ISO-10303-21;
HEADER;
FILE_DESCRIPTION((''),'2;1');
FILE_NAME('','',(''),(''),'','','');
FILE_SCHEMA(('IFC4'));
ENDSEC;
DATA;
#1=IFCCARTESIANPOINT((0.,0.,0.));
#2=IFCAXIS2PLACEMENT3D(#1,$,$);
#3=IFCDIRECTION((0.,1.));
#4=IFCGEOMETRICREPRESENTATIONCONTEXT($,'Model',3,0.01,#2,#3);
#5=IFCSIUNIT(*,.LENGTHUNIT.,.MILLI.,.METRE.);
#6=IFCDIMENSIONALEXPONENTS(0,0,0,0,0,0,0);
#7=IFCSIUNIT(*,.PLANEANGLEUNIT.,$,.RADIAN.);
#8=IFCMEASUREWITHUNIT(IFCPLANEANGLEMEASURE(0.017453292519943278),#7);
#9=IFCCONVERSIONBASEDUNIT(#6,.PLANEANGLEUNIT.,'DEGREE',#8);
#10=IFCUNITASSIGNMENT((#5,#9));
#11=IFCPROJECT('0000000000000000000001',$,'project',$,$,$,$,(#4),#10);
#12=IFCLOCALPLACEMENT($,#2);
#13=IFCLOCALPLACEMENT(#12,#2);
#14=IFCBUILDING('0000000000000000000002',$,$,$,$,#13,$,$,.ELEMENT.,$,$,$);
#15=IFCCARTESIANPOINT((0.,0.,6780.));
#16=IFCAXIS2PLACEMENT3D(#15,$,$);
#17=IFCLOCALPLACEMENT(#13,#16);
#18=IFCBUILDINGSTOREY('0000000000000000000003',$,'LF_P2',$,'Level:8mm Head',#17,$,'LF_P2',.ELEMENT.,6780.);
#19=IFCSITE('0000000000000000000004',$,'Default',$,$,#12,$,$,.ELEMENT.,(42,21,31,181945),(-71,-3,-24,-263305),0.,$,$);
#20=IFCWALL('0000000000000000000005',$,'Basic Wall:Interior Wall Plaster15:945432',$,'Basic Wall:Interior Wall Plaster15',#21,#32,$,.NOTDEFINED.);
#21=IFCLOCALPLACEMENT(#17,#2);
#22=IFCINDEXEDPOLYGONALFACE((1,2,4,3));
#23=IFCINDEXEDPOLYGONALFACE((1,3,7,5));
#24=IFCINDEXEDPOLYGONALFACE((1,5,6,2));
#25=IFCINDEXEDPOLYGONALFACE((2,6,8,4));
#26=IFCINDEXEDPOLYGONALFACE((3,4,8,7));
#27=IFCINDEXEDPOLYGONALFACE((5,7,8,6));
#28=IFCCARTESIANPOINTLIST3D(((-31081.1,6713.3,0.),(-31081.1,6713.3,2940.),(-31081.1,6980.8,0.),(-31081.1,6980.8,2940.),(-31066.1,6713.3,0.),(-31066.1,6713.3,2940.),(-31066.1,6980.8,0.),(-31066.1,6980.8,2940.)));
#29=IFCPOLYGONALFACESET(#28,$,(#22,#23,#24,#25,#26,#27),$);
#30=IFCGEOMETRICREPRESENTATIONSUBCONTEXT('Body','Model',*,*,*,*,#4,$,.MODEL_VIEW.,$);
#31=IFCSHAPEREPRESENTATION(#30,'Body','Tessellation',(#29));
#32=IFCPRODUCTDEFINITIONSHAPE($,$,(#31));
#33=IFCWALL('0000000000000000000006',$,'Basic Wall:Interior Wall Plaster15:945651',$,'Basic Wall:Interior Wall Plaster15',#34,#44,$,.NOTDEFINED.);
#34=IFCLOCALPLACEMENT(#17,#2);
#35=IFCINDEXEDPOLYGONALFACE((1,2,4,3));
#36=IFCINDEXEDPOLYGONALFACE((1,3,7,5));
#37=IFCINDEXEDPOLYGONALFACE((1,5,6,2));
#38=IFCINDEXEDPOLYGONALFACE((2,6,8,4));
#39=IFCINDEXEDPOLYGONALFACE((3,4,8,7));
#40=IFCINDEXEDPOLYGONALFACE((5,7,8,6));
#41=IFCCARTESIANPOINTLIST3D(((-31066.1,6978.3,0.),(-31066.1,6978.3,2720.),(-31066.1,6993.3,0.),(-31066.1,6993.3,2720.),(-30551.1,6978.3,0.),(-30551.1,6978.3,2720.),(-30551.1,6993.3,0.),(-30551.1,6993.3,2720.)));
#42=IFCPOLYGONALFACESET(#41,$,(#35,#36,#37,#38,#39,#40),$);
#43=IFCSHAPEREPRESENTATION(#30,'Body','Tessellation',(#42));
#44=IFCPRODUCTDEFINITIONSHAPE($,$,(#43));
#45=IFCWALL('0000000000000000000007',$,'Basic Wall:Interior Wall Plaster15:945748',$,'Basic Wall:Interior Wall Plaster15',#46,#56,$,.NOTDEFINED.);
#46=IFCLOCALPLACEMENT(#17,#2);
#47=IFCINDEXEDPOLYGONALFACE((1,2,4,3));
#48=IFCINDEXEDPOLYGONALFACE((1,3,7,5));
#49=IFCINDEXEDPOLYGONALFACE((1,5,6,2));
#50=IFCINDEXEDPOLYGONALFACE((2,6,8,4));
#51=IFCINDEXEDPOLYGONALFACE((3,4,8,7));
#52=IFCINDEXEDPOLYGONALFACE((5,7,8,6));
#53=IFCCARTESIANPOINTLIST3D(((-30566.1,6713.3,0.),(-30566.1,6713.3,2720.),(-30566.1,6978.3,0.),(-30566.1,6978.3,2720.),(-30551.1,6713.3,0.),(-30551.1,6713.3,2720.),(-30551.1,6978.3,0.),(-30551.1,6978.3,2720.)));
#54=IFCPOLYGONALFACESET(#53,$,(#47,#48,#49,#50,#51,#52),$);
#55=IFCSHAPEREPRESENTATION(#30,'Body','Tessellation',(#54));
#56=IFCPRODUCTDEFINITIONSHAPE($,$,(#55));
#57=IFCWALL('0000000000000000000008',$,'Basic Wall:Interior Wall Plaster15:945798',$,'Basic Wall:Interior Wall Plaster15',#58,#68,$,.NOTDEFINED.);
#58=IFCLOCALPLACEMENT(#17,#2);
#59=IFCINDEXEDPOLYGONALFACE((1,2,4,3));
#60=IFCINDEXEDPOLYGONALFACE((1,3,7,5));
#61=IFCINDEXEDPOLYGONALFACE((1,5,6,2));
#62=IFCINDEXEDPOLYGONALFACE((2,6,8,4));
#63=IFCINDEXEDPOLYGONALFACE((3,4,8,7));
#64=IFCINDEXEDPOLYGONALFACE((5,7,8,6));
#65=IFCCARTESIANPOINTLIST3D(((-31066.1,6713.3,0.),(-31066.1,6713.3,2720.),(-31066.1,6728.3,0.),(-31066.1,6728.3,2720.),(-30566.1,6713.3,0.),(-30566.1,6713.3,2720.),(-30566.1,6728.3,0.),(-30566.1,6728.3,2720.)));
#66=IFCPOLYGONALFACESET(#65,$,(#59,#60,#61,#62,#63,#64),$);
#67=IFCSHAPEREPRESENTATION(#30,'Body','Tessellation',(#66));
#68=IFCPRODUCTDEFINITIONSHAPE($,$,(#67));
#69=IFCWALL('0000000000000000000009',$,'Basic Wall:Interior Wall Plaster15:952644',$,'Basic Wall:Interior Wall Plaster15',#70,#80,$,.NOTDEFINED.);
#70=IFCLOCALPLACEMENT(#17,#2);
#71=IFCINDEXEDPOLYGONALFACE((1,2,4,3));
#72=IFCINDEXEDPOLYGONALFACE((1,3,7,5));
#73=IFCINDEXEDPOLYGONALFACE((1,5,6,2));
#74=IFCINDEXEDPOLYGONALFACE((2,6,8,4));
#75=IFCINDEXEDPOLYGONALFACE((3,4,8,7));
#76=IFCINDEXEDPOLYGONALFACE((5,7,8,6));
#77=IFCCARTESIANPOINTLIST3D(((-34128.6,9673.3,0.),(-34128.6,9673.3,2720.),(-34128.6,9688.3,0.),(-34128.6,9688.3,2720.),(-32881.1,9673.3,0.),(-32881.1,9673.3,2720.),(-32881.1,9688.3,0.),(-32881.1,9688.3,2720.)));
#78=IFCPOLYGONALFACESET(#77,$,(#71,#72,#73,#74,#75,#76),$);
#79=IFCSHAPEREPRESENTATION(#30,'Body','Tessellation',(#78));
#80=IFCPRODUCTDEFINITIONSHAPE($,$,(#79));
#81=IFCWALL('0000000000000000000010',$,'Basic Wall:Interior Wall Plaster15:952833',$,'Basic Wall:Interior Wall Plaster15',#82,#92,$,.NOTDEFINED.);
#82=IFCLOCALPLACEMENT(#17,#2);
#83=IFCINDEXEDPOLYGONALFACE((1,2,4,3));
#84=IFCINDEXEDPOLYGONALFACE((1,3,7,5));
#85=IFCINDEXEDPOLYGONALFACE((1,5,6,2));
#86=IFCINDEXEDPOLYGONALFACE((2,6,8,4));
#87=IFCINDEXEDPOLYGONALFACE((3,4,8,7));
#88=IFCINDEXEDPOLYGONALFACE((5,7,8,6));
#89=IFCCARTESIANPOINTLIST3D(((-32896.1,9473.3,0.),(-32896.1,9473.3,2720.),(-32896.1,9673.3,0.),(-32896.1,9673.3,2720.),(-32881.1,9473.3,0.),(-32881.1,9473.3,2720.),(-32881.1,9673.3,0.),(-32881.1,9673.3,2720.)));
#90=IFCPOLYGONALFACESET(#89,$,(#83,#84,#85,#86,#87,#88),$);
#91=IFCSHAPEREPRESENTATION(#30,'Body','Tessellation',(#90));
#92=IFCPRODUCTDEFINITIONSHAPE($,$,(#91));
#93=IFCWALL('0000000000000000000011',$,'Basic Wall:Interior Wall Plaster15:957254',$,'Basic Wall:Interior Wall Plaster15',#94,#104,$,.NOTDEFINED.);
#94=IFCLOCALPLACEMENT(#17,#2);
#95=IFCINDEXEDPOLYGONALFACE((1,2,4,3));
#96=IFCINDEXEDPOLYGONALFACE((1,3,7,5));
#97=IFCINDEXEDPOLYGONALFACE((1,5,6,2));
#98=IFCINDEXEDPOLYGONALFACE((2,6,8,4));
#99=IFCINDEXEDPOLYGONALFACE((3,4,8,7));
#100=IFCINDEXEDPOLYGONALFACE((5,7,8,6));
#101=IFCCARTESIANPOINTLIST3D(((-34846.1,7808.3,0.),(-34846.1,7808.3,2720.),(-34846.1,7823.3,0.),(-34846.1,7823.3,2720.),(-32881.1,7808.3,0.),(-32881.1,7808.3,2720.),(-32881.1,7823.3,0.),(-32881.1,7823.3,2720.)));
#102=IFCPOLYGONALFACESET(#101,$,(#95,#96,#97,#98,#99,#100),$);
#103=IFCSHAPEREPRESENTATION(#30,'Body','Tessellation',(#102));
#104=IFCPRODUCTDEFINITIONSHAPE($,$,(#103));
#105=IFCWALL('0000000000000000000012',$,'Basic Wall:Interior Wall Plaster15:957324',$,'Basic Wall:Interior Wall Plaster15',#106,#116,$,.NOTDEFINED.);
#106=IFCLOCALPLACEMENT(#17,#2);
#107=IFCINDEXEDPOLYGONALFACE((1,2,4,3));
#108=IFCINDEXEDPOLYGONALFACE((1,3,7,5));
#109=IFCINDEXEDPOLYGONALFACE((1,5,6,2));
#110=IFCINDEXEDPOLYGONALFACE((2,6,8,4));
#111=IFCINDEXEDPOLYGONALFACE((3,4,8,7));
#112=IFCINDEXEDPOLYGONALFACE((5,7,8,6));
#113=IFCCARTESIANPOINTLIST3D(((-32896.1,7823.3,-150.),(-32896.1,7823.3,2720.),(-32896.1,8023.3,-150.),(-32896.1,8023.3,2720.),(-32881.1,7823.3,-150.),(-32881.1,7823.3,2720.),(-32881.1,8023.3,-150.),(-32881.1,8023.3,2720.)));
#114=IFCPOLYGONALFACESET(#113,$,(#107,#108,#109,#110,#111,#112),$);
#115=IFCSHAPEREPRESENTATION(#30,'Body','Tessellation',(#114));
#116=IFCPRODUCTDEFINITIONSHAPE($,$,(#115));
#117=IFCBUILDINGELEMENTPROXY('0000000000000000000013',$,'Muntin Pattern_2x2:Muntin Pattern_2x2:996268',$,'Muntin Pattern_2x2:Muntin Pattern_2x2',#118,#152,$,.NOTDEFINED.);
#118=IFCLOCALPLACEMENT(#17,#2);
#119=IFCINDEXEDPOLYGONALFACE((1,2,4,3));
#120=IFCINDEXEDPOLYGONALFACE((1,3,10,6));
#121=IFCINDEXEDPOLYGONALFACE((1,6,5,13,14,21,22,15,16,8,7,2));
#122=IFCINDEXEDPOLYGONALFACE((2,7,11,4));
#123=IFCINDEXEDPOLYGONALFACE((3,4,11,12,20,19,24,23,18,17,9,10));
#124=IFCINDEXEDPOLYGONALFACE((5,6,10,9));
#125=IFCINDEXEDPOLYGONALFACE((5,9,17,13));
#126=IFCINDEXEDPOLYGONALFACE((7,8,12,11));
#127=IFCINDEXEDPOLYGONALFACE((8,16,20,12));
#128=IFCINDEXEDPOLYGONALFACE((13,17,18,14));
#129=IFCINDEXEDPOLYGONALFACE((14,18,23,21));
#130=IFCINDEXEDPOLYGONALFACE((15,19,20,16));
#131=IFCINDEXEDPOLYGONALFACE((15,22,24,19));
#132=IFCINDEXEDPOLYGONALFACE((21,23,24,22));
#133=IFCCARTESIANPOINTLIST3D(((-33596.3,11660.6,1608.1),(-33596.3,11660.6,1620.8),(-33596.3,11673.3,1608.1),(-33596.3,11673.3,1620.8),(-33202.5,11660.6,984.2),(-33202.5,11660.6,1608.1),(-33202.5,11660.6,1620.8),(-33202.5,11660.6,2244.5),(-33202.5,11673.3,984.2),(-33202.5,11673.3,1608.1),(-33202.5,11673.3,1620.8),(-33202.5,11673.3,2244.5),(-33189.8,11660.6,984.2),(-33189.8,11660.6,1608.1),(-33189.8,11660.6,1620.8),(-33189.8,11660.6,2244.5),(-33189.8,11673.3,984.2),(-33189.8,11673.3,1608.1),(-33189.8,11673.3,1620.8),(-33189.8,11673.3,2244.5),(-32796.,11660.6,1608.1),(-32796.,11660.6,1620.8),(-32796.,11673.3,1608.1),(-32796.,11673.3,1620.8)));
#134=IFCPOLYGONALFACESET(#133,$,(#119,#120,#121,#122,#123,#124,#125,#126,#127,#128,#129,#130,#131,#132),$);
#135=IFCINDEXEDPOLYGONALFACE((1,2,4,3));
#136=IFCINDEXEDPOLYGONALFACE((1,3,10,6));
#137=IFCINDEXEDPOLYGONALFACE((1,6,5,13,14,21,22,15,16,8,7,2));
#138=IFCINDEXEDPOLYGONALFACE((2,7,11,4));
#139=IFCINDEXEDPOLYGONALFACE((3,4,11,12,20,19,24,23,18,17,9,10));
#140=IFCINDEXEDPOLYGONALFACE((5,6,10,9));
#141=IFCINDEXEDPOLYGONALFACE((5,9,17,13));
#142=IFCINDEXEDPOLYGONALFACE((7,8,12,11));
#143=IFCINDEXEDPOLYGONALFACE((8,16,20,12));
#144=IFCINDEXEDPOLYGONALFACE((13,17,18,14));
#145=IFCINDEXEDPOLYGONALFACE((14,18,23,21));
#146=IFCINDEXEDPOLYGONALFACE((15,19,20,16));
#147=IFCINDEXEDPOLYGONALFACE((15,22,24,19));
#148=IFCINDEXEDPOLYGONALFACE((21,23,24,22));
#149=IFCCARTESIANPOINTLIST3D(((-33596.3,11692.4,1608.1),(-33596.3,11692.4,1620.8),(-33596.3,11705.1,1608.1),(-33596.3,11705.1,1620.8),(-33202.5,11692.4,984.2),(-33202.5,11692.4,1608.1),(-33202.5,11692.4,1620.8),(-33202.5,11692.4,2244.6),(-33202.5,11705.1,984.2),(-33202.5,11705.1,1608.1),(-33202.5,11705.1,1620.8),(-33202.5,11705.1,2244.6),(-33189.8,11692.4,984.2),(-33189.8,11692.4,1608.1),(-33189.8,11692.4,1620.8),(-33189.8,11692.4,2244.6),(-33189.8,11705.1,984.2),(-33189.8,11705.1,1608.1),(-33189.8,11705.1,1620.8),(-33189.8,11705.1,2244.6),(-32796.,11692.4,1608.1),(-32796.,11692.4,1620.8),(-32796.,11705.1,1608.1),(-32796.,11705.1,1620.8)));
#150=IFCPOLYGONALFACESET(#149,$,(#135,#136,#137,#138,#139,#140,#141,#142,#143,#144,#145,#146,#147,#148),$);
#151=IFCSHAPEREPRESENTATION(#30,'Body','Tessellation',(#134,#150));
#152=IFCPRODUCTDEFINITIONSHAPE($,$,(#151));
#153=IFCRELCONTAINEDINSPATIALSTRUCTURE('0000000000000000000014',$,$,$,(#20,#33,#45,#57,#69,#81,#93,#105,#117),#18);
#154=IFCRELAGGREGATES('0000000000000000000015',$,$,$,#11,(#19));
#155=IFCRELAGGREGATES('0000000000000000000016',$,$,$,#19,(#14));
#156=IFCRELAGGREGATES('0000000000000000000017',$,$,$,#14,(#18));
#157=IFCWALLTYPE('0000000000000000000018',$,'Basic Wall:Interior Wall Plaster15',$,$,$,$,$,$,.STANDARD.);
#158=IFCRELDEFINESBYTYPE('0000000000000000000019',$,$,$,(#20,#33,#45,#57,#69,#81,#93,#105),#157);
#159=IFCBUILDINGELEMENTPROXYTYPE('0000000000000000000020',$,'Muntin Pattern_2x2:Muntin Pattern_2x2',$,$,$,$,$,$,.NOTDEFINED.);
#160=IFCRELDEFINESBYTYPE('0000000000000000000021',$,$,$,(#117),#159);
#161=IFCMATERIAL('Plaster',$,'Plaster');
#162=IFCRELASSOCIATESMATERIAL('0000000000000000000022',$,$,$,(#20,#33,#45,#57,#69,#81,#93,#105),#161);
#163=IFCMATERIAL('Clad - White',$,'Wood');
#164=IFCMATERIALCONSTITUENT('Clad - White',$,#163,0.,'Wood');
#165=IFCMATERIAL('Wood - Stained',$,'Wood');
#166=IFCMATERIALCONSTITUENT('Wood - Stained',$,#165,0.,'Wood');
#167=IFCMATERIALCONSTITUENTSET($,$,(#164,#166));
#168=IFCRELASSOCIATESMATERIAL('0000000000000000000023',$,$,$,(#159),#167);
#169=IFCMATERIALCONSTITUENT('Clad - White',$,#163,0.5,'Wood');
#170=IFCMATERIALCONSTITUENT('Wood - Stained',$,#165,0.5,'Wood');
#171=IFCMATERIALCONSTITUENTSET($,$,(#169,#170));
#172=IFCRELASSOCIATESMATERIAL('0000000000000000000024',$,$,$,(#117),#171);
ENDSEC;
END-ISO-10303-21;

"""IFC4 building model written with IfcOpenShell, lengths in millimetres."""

from ifc_helpers import new_model, entity, si_unit, converted_unit, direction, frame, origin, place, context, subcontext, project, spatial, indexed_curve, outline, extrude, source, transform, mapped, material, constituent, constituent_set, type_object, type_shapes, element, save


model = new_model("IFC4")

# Units and contexts
model_context = context("Model", 3, precision=0.01, world=origin(), true_north=direction((0.0, 1.0)))
body_context = subcontext(model_context, "Body", "Model", "MODEL_VIEW")
ifc_project = project(units=[si_unit("LENGTHUNIT", "METRE", prefix="MILLI"), converted_unit("PLANEANGLEUNIT", "DEGREE", entity("IfcPlaneAngleMeasure", 0.017453292519943278), si_unit("PLANEANGLEUNIT", "RADIAN"), dimensions=[0, 0, 0, 0, 0, 0, 0])], contexts=[model_context])

# Site, building, storey
site_placement = place(None, origin())
site = spatial("IfcSite", under=ifc_project, at=site_placement, Name="Default", CompositionType="ELEMENT", RefLatitude=(42, 21, 31, 181945), RefLongitude=(-71, -3, -24, -263305), RefElevation=0.0)
building_placement = place(site_placement, origin())
building = spatial("IfcBuilding", under=site, at=building_placement, CompositionType="ELEMENT")
storey_placement = place(building_placement, frame((0.0, 0.0, 6780.0)))
storey = spatial("IfcBuildingStorey", under=building, at=storey_placement, Name="LF_P2", ObjectType="Level:8mm Head", LongName="LF_P2", CompositionType="ELEMENT", Elevation=6780.0)

# Walls
ifc_material_1 = material(Name="Plaster", Category="Plaster")
wall_type_1 = type_object("IfcWallType", Name="Basic Wall:Interior Wall Plaster15", PredefinedType="STANDARD")
wall_1_placement = place(storey_placement, frame((-31073.6, 6980.8, 0.0), z_axis=(0.0, 0.0, 1.0), x_axis=(0.0, -1.0, 0.0)))
element("IfcWall", 1, at=wall_1_placement, inside=storey, type_object=wall_type_1, material=ifc_material_1, Name="Basic Wall:Interior Wall Plaster15:945432", ObjectType="Basic Wall:Interior Wall Plaster15", PredefinedType="NOTDEFINED", context=body_context, shape_type="SweptSolid", body=[
    extrude(outline(indexed_curve([(267.5, 7.5), (0.0, 7.5), (0.0, -7.5), (267.5, -7.5), (267.5, 7.5)], self_intersect=False)), origin(), (0.0, 0.0, 1.0), 2940.0),
])
wall_2_placement = place(storey_placement, frame((-31066.1, 6985.8, 0.0)))
element("IfcWall", 2, at=wall_2_placement, inside=storey, type_object=wall_type_1, material=ifc_material_1, Name="Basic Wall:Interior Wall Plaster15:945651", ObjectType="Basic Wall:Interior Wall Plaster15", PredefinedType="NOTDEFINED", context=body_context, shape_type="SweptSolid", body=[
    extrude(outline(indexed_curve([(515.0, 7.5), (0.0, 7.5), (0.0, -7.5), (515.0, -7.5), (515.0, 7.5)], self_intersect=False)), origin(), (0.0, 0.0, 1.0), 2720.0),
])
wall_3_placement = place(storey_placement, frame((-30558.6, 6978.3, 0.0), z_axis=(0.0, 0.0, 1.0), x_axis=(0.0, -1.0, 0.0)))
element("IfcWall", 3, at=wall_3_placement, inside=storey, type_object=wall_type_1, material=ifc_material_1, Name="Basic Wall:Interior Wall Plaster15:945748", ObjectType="Basic Wall:Interior Wall Plaster15", PredefinedType="NOTDEFINED", context=body_context, shape_type="SweptSolid", body=[
    extrude(outline(indexed_curve([(265.0, 7.5), (0.0, 7.5), (0.0, -7.5), (265.0, -7.5), (265.0, 7.5)], self_intersect=False)), origin(), (0.0, 0.0, 1.0), 2720.0),
])
wall_4_placement = place(storey_placement, frame((-30566.1, 6720.8, 0.0), z_axis=(0.0, 0.0, 1.0), x_axis=(-1.0, 0.0, 0.0)))
element("IfcWall", 4, at=wall_4_placement, inside=storey, type_object=wall_type_1, material=ifc_material_1, Name="Basic Wall:Interior Wall Plaster15:945798", ObjectType="Basic Wall:Interior Wall Plaster15", PredefinedType="NOTDEFINED", context=body_context, shape_type="SweptSolid", body=[
    extrude(outline(indexed_curve([(500.0, 7.5), (0.0, 7.5), (0.0, -7.5), (500.0, -7.5), (500.0, 7.5)], self_intersect=False)), origin(), (0.0, 0.0, 1.0), 2720.0),
])
wall_5_placement = place(storey_placement, frame((-34128.6, 9680.8, 0.0)))
element("IfcWall", 5, at=wall_5_placement, inside=storey, type_object=wall_type_1, material=ifc_material_1, Name="Basic Wall:Interior Wall Plaster15:952644", ObjectType="Basic Wall:Interior Wall Plaster15", PredefinedType="NOTDEFINED", context=body_context, shape_type="SweptSolid", body=[
    extrude(outline(indexed_curve([(1247.5, 7.5), (0.0, 7.5), (0.0, -7.5), (1247.5, -7.5), (1247.5, 7.5)], self_intersect=False)), origin(), (0.0, 0.0, 1.0), 2720.0),
])
wall_6_placement = place(storey_placement, frame((-32888.6, 9673.3, 0.0), z_axis=(0.0, 0.0, 1.0), x_axis=(0.0, -1.0, 0.0)))
element("IfcWall", 6, at=wall_6_placement, inside=storey, type_object=wall_type_1, material=ifc_material_1, Name="Basic Wall:Interior Wall Plaster15:952833", ObjectType="Basic Wall:Interior Wall Plaster15", PredefinedType="NOTDEFINED", context=body_context, shape_type="SweptSolid", body=[
    extrude(outline(indexed_curve([(200.0, 7.5), (0.0, 7.5), (0.0, -7.5), (200.0, -7.5), (200.0, 7.5)], self_intersect=False)), origin(), (0.0, 0.0, 1.0), 2720.0),
])
wall_7_placement = place(storey_placement, frame((-34846.1, 7815.8, 0.0)))
element("IfcWall", 7, at=wall_7_placement, inside=storey, type_object=wall_type_1, material=ifc_material_1, Name="Basic Wall:Interior Wall Plaster15:957254", ObjectType="Basic Wall:Interior Wall Plaster15", PredefinedType="NOTDEFINED", context=body_context, shape_type="SweptSolid", body=[
    extrude(outline(indexed_curve([(1965.0, 7.5), (0.0, 7.5), (0.0, -7.5), (1965.0, -7.5), (1965.0, 7.5)], self_intersect=False)), origin(), (0.0, 0.0, 1.0), 2720.0),
])
wall_8_placement = place(storey_placement, frame((-32888.6, 7823.3, -150.0), z_axis=(0.0, 0.0, 1.0), x_axis=(0.0, 1.0, 0.0)))
element("IfcWall", 8, at=wall_8_placement, inside=storey, type_object=wall_type_1, material=ifc_material_1, Name="Basic Wall:Interior Wall Plaster15:957324", ObjectType="Basic Wall:Interior Wall Plaster15", PredefinedType="NOTDEFINED", context=body_context, shape_type="SweptSolid", body=[
    extrude(outline(indexed_curve([(200.0, 7.5), (0.0, 7.5), (0.0, -7.5), (200.0, -7.5), (200.0, 7.5)], self_intersect=False)), origin(), (0.0, 0.0, 1.0), 2870.0),
])

# Building element proxy
ifc_material_2 = material(Name="Clad - White", Category="Wood")
ifc_constituent_1 = constituent(ifc_material_2, Name="Clad - White", Category="Wood", fraction=0.5)
ifc_material_3 = material(Name="Wood - Stained", Category="Wood")
ifc_constituent_2 = constituent(ifc_material_3, Name="Wood - Stained", Category="Wood", fraction=0.5)
ifc_constituent_set_1 = constituent_set(constituents=[ifc_constituent_1, ifc_constituent_2])
ifc_constituent_3 = constituent(ifc_material_2, Name="Clad - White", Category="Wood", fraction=0.0)
ifc_constituent_4 = constituent(ifc_material_3, Name="Wood - Stained", Category="Wood", fraction=0.0)
ifc_constituent_set_2 = constituent_set(constituents=[ifc_constituent_3, ifc_constituent_4])
building_element_proxy_type_1 = type_object("IfcBuildingElementProxyType", Name="Muntin Pattern_2x2:Muntin Pattern_2x2", PredefinedType="NOTDEFINED", material=ifc_constituent_set_2)
shared_shape_1 = source(origin(), body_context, "Body", "SweptSolid", [
    extrude(outline(indexed_curve([(6.4, -6.4), (630.1, -6.4), (630.1, 6.3), (6.4, 6.3), (6.4, 400.2), (-6.3, 400.2), (-6.3, 6.3), (-630.2, 6.3), (-630.2, -6.4), (-6.3, -6.4), (-6.3, -400.1), (6.4, -400.1), (6.4, -6.4)], self_intersect=False)), frame((0.0, 9.5, 630.1), z_axis=(0.0, 1.0, 0.0), x_axis=(0.0, 0.0, 1.0)), (0.0, 0.0, 1.0), 12.7),
    extrude(outline(indexed_curve([(6.4, -6.4), (630.2, -6.4), (630.2, 6.3), (6.4, 6.3), (6.4, 400.2), (-6.3, 400.2), (-6.3, 6.3), (-630.2, 6.3), (-630.2, -6.4), (-6.3, -6.4), (-6.3, -400.1), (6.4, -400.1), (6.4, -6.4)], self_intersect=False)), frame((0.0, -22.2, 630.2), z_axis=(0.0, 1.0, 0.0), x_axis=(0.0, 0.0, 1.0)), (0.0, 0.0, 1.0), 12.7),
])
type_shapes(building_element_proxy_type_1, [shared_shape_1])
proxy_1_placement = place(storey_placement, frame((-33196.1, 11682.9, 984.3), z_axis=(0.0, 0.0, 1.0), x_axis=(-1.0, 0.0, 0.0)))
element("IfcBuildingElementProxy", 9, at=proxy_1_placement, inside=storey, type_object=building_element_proxy_type_1, material=ifc_constituent_set_1, Name="Muntin Pattern_2x2:Muntin Pattern_2x2:996268", ObjectType="Muntin Pattern_2x2:Muntin Pattern_2x2", PredefinedType="NOTDEFINED", context=body_context, shape_type="MappedRepresentation", body=[
    mapped(shared_shape_1, transform((0.0, 0.0, 0.0), scale=1.0)),
])

save(model, "model.ifc")
